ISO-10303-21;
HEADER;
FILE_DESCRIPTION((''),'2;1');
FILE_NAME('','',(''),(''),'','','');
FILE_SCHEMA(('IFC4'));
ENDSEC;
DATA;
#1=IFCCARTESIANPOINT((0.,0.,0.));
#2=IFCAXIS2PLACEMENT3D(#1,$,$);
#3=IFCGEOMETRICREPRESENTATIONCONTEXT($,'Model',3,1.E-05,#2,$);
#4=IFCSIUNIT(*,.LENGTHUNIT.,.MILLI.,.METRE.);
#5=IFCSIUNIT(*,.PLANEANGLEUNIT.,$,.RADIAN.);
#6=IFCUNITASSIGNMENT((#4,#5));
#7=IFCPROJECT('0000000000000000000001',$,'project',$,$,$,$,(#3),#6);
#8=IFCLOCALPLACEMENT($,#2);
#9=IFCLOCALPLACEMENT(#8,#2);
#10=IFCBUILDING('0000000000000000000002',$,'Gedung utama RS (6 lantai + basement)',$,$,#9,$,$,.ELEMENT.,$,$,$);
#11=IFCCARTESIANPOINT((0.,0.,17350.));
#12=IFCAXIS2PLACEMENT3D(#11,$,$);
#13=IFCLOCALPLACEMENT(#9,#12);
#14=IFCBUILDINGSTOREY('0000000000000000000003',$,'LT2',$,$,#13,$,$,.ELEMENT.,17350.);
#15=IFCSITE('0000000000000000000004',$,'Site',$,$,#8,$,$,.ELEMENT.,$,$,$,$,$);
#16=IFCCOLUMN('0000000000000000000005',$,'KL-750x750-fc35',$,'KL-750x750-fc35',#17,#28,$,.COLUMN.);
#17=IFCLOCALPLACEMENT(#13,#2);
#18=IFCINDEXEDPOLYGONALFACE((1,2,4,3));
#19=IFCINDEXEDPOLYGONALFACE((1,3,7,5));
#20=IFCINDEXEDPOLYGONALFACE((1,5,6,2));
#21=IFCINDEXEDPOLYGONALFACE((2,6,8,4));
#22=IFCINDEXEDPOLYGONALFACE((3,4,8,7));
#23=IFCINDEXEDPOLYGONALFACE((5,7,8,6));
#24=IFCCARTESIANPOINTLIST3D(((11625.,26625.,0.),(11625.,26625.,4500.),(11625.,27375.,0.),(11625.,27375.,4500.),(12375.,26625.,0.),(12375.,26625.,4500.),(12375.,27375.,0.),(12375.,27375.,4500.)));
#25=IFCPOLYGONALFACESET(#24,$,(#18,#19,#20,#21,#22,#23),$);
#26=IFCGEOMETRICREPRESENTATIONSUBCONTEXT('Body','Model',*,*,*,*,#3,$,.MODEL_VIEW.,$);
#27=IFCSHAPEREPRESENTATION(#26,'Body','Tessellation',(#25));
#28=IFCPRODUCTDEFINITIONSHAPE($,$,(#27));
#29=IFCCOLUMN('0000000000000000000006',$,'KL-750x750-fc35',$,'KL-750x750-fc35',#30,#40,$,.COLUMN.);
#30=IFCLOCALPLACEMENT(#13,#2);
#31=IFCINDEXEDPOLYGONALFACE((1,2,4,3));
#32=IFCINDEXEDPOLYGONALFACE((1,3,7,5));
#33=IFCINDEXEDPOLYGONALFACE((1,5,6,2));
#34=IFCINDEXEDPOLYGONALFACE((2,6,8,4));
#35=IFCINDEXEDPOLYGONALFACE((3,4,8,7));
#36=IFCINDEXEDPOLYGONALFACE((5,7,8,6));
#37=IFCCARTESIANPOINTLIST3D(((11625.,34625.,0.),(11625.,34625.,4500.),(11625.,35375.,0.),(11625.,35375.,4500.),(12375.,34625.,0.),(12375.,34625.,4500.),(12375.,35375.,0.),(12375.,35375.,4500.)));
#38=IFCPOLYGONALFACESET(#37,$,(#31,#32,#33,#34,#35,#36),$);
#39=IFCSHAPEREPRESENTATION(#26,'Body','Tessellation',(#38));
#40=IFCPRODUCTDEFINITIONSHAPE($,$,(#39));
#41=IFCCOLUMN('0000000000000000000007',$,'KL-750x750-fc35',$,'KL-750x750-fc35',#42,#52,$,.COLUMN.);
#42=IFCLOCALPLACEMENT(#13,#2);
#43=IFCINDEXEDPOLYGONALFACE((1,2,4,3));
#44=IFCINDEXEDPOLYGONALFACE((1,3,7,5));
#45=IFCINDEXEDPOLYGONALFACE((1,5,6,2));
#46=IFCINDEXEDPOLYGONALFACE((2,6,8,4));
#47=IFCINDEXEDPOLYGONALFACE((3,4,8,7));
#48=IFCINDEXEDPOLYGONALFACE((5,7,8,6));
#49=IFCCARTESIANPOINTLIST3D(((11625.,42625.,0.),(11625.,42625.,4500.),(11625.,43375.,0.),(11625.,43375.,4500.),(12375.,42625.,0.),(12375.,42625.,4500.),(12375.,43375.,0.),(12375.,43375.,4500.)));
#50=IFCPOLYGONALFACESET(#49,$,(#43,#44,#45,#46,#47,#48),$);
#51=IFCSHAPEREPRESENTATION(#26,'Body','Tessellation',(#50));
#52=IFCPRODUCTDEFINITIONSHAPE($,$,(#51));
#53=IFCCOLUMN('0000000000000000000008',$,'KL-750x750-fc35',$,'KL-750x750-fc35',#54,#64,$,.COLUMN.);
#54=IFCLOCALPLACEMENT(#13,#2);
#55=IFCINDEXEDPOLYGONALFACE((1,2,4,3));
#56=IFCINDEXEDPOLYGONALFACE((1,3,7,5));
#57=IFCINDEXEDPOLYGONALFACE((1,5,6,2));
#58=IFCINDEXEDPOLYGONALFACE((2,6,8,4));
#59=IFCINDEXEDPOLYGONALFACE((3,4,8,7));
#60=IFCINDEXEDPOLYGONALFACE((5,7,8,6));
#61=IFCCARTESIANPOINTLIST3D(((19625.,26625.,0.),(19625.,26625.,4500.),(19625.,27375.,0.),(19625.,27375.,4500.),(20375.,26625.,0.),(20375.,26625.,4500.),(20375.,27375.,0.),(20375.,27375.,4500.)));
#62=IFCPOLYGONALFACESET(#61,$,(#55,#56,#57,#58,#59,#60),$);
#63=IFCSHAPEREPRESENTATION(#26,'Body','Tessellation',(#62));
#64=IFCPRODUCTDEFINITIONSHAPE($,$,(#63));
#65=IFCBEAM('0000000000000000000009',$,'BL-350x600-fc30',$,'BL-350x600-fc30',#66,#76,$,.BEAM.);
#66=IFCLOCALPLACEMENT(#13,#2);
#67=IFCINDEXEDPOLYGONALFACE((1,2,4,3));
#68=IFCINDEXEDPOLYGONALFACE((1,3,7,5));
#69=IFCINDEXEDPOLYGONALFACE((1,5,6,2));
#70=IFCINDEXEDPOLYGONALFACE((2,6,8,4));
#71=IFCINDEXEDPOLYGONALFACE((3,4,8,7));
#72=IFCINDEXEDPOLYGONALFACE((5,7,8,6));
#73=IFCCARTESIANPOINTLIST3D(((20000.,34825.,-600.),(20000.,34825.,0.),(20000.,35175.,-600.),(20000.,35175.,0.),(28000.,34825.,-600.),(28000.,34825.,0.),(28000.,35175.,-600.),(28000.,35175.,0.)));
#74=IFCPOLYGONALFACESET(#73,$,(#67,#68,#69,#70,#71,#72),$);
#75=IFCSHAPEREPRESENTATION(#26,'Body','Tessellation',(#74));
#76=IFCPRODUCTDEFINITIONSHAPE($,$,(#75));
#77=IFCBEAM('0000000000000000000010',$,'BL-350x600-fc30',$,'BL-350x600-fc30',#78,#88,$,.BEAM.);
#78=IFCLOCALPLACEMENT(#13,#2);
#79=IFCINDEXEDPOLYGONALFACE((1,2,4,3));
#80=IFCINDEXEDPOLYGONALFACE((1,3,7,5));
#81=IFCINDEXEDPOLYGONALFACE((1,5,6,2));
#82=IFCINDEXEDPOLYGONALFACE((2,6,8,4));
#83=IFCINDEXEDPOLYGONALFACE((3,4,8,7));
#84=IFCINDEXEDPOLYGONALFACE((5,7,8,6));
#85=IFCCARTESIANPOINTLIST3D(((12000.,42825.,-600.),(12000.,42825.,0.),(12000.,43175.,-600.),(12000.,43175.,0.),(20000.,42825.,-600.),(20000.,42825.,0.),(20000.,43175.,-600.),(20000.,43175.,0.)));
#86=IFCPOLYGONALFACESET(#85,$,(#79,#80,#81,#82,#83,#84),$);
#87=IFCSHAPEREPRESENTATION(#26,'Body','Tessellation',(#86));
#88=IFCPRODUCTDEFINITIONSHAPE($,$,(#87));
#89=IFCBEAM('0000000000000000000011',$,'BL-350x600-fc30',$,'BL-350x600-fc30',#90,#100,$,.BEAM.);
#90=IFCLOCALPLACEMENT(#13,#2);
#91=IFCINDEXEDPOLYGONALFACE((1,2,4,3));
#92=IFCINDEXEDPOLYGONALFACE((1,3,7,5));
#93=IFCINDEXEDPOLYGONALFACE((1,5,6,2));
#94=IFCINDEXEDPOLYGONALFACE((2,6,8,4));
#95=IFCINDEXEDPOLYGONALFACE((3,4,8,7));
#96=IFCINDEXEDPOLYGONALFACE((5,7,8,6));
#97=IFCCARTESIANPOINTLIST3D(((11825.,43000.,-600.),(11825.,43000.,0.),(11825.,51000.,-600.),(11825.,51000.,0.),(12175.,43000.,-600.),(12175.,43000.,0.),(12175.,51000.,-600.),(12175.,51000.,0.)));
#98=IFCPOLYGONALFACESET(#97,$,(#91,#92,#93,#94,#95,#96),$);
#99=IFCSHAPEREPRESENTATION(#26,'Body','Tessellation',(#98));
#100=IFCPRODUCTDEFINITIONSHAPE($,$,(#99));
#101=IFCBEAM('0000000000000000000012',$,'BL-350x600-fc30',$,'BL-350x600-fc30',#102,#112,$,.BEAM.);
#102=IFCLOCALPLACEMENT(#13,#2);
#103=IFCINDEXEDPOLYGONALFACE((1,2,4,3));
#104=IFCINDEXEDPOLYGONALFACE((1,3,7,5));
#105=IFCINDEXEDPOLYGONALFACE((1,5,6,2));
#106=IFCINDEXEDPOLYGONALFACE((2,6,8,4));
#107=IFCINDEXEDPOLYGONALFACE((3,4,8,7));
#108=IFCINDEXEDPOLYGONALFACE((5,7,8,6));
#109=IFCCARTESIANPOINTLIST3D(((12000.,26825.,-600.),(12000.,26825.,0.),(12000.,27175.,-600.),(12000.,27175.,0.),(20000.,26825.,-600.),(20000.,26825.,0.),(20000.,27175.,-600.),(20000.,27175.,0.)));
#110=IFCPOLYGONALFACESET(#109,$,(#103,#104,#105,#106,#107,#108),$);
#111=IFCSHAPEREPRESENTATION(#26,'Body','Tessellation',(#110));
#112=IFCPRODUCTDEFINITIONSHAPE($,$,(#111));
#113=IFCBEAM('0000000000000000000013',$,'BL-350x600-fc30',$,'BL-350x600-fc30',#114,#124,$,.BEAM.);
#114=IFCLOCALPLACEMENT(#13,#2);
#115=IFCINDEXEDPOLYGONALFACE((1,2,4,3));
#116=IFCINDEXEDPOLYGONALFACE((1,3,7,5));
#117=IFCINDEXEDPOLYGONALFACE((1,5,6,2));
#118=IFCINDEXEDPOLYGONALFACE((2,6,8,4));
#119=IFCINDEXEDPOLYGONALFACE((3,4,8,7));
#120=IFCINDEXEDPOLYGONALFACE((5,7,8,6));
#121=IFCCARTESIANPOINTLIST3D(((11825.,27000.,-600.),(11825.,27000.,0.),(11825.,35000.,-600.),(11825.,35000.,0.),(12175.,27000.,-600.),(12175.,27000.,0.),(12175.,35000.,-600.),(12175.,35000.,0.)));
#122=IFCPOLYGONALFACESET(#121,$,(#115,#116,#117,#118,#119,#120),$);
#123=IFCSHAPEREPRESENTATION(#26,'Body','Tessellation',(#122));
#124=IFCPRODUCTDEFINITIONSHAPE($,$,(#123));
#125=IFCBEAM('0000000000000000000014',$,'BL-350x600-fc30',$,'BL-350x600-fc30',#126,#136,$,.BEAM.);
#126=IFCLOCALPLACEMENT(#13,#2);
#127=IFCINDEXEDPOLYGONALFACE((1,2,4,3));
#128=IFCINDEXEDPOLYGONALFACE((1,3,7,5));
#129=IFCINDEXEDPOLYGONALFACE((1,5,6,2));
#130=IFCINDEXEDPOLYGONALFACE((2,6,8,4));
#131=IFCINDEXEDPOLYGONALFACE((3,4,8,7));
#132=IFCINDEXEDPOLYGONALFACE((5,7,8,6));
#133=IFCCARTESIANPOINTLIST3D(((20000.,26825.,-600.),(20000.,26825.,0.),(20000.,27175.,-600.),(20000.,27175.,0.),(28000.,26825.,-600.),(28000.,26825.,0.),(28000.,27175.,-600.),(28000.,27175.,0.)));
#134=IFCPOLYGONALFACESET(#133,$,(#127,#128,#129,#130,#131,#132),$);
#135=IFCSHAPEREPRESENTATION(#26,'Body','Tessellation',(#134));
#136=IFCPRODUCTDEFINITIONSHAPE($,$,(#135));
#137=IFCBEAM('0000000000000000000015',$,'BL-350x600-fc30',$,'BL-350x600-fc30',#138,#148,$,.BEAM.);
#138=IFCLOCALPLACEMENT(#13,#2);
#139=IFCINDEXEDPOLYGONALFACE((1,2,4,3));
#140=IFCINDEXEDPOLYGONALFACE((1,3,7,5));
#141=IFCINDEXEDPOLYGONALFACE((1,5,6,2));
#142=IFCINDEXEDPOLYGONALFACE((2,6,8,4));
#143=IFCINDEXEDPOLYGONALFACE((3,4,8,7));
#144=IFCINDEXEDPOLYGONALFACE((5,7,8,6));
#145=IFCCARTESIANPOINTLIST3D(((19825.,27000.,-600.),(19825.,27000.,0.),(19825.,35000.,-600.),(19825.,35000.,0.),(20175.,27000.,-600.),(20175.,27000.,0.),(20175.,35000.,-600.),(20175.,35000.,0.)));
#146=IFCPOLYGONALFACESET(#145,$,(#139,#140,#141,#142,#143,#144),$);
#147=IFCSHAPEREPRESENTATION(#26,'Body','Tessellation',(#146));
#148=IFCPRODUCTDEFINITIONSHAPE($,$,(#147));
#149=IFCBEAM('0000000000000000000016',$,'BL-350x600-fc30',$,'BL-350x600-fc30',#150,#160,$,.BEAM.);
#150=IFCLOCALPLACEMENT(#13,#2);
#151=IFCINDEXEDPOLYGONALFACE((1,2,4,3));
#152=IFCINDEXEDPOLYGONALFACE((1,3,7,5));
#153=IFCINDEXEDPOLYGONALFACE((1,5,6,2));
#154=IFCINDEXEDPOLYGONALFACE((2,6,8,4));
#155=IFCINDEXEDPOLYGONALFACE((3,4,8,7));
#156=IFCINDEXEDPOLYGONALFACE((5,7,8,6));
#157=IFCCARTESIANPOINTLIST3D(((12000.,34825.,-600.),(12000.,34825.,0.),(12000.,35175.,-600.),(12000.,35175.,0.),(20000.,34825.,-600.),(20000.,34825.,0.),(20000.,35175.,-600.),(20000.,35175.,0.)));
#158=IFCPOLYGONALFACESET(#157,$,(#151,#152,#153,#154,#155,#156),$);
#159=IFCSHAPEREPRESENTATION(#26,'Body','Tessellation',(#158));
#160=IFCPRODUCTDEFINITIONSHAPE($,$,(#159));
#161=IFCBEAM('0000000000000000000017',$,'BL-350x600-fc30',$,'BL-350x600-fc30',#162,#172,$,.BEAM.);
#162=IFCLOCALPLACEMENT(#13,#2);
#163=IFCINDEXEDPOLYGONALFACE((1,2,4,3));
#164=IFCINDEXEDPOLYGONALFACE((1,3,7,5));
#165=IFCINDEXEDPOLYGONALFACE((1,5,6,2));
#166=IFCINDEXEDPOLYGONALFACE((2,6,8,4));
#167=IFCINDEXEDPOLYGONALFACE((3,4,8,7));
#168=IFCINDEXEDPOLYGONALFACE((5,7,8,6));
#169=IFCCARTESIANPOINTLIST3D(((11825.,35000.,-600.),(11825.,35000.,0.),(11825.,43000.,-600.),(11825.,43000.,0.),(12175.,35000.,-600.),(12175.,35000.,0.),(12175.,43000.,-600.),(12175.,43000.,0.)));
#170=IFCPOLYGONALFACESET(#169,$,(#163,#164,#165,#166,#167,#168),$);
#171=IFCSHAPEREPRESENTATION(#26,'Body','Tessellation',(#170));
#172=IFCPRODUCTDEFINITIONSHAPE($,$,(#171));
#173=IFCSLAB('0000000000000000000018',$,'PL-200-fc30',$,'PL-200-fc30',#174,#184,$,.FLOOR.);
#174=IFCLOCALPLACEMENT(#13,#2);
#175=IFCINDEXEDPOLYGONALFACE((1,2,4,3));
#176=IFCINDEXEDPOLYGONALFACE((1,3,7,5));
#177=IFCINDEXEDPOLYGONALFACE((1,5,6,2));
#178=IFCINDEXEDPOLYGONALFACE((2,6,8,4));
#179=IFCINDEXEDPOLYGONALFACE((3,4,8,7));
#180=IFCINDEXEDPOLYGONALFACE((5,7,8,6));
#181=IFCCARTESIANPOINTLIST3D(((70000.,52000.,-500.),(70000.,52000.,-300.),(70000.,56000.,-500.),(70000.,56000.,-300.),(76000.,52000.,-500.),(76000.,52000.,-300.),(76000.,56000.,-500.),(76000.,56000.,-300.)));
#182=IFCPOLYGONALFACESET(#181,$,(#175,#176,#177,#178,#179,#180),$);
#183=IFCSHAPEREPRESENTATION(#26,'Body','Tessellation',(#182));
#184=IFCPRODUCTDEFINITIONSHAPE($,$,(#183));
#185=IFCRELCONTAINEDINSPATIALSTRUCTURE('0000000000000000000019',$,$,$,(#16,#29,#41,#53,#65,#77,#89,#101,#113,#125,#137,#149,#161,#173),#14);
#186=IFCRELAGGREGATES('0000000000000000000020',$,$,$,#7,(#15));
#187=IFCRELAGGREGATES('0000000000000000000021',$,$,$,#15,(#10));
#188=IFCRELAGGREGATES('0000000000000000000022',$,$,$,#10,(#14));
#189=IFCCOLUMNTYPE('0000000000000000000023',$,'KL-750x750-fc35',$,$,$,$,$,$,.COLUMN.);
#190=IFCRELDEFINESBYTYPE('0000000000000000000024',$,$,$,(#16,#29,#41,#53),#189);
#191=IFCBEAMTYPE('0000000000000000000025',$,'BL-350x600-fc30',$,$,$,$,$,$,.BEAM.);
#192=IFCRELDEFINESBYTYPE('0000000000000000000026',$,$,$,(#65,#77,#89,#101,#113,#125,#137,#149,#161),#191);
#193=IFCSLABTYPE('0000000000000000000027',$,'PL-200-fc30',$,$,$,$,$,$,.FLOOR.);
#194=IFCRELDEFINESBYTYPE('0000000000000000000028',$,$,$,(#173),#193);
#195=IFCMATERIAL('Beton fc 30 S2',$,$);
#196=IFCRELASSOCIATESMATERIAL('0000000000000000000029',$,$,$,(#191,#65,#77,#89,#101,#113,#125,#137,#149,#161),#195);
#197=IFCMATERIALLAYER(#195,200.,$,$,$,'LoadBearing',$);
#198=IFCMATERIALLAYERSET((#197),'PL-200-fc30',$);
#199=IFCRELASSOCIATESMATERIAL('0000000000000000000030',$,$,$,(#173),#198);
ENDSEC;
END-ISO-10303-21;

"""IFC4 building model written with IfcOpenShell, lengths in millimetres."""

from ifc_helpers import new_model, si_unit, frame, origin, origin_2d, place, context, subcontext, project, spatial, polyline, rectangle, outline, extrude, material, layer, layer_set, layer_usage, material_profile, profile_set, profile_usage, type_object, element, save


model = new_model("IFC4")

# Units and contexts
model_context = context("Model", 3, precision=1e-05, world=origin())
body_context = subcontext(model_context, "Body", "Model", "MODEL_VIEW")
ifc_project = project(units=[si_unit("LENGTHUNIT", "METRE", prefix="MILLI"), si_unit("PLANEANGLEUNIT", "RADIAN")], contexts=[model_context])

# Site, building, storey
site_placement = place(None, origin())
site = spatial("IfcSite", under=ifc_project, at=site_placement, Name="Site", CompositionType="ELEMENT")
building_placement = place(site_placement, origin())
building = spatial("IfcBuilding", under=site, at=building_placement, Name="Gedung utama RS (6 lantai + basement)", CompositionType="ELEMENT")
storey_placement = place(building_placement, frame((0.0, 0.0, 17350.0)))
storey = spatial("IfcBuildingStorey", under=building, at=storey_placement, Name="LT2", CompositionType="ELEMENT", Elevation=17350.0)

# Columns
ifc_material_profile_1 = material_profile(None, rectangle(XDim=750.0, YDim=750.0, at=origin_2d()), Name="KL-750x750-fc35")
ifc_profile_set_1 = profile_set([ifc_material_profile_1], Name="KL-750x750-fc35")
ifc_profile_usage_1 = profile_usage(ifc_profile_set_1, cardinal=5)
column_type = type_object("IfcColumnType", Name="KL-750x750-fc35", PredefinedType="COLUMN", material=ifc_profile_set_1)
for number, where, z_axis, x_axis, name in (
    (1, (12000.0, 27000.0, 0.0), (0.0, 0.0, 1.0), (1.0, 0.0, 0.0), "KL-750x750-fc35"),
    (2, (12000.0, 35000.0, 0.0), (0.0, 0.0, 1.0), (1.0, 0.0, 0.0), "KL-750x750-fc35"),
    (3, (12000.0, 43000.0, 0.0), (0.0, 0.0, 1.0), (1.0, 0.0, 0.0), "KL-750x750-fc35"),
    (4, (20000.0, 27000.0, 0.0), (0.0, 0.0, 1.0), (1.0, 0.0, 0.0), "KL-750x750-fc35"),
):
    element("IfcColumn", number, at=place(storey_placement, frame(where, z_axis=z_axis, x_axis=x_axis)), inside=storey, type_object=column_type, material=ifc_profile_usage_1, Name=name, ObjectType="KL-750x750-fc35", PredefinedType="COLUMN", context=body_context, shape_type="SweptSolid", body=[
        extrude(rectangle(XDim=750.0, YDim=750.0, at=origin_2d()), origin(), (0.0, 0.0, 1.0), 4500.0),
    ])

# Beams
ifc_material = material(Name="Beton fc 30 S2")
ifc_material_profile_2 = material_profile(ifc_material, rectangle(XDim=350.0, YDim=600.0, at=origin_2d()), Name="BL-350x600-fc30")
ifc_profile_set_2 = profile_set([ifc_material_profile_2], Name="BL-350x600-fc30")
ifc_profile_usage_2 = profile_usage(ifc_profile_set_2, cardinal=8)
beam_type = type_object("IfcBeamType", Name="BL-350x600-fc30", PredefinedType="BEAM", material=ifc_profile_set_2)
for number, where, name in (
    (5, (20000.0, 35000.0, -300.0), "BL-350x600-fc30"),
    (6, (12000.0, 43000.0, -300.0), "BL-350x600-fc30"),
):
    element("IfcBeam", number, at=place(storey_placement, frame(where)), inside=storey, type_object=beam_type, material=ifc_profile_usage_2, Name=name, ObjectType="BL-350x600-fc30", PredefinedType="BEAM", context=body_context, shape_type="SweptSolid", body=[
        extrude(rectangle(XDim=350.0, YDim=600.0, at=origin_2d()), frame((0.0, 0.0, 0.0), z_axis=(1.0, 0.0, 0.0), x_axis=(0.0, 1.0, 0.0)), (0.0, 0.0, 1.0), 8000.0),
    ])
beam_1_placement = place(storey_placement, frame((12000.0, 43000.0, -300.0)))
element("IfcBeam", 7, at=beam_1_placement, inside=storey, type_object=beam_type, material=ifc_profile_usage_2, Name="BL-350x600-fc30", ObjectType="BL-350x600-fc30", PredefinedType="BEAM", context=body_context, shape_type="SweptSolid", body=[
    extrude(rectangle(XDim=350.0, YDim=600.0, at=origin_2d()), frame((0.0, 0.0, 0.0), z_axis=(0.0, 1.0, 0.0), x_axis=(-1.0, 0.0, 0.0)), (0.0, 0.0, 1.0), 8000.0),
])
beam_2_placement = place(storey_placement, frame((12000.0, 27000.0, -300.0)))
element("IfcBeam", 8, at=beam_2_placement, inside=storey, type_object=beam_type, material=ifc_profile_usage_2, Name="BL-350x600-fc30", ObjectType="BL-350x600-fc30", PredefinedType="BEAM", context=body_context, shape_type="SweptSolid", body=[
    extrude(rectangle(XDim=350.0, YDim=600.0, at=origin_2d()), frame((0.0, 0.0, 0.0), z_axis=(1.0, 0.0, 0.0), x_axis=(0.0, 1.0, 0.0)), (0.0, 0.0, 1.0), 8000.0),
])
beam_3_placement = place(storey_placement, frame((12000.0, 27000.0, -300.0)))
element("IfcBeam", 9, at=beam_3_placement, inside=storey, type_object=beam_type, material=ifc_profile_usage_2, Name="BL-350x600-fc30", ObjectType="BL-350x600-fc30", PredefinedType="BEAM", context=body_context, shape_type="SweptSolid", body=[
    extrude(rectangle(XDim=350.0, YDim=600.0, at=origin_2d()), frame((0.0, 0.0, 0.0), z_axis=(0.0, 1.0, 0.0), x_axis=(-1.0, 0.0, 0.0)), (0.0, 0.0, 1.0), 8000.0),
])
beam_4_placement = place(storey_placement, frame((20000.0, 27000.0, -300.0)))
element("IfcBeam", 10, at=beam_4_placement, inside=storey, type_object=beam_type, material=ifc_profile_usage_2, Name="BL-350x600-fc30", ObjectType="BL-350x600-fc30", PredefinedType="BEAM", context=body_context, shape_type="SweptSolid", body=[
    extrude(rectangle(XDim=350.0, YDim=600.0, at=origin_2d()), frame((0.0, 0.0, 0.0), z_axis=(1.0, 0.0, 0.0), x_axis=(0.0, 1.0, 0.0)), (0.0, 0.0, 1.0), 8000.0),
])
beam_5_placement = place(storey_placement, frame((20000.0, 27000.0, -300.0)))
element("IfcBeam", 11, at=beam_5_placement, inside=storey, type_object=beam_type, material=ifc_profile_usage_2, Name="BL-350x600-fc30", ObjectType="BL-350x600-fc30", PredefinedType="BEAM", context=body_context, shape_type="SweptSolid", body=[
    extrude(rectangle(XDim=350.0, YDim=600.0, at=origin_2d()), frame((0.0, 0.0, 0.0), z_axis=(0.0, 1.0, 0.0), x_axis=(-1.0, 0.0, 0.0)), (0.0, 0.0, 1.0), 8000.0),
])
beam_6_placement = place(storey_placement, frame((12000.0, 35000.0, -300.0)))
element("IfcBeam", 12, at=beam_6_placement, inside=storey, type_object=beam_type, material=ifc_profile_usage_2, Name="BL-350x600-fc30", ObjectType="BL-350x600-fc30", PredefinedType="BEAM", context=body_context, shape_type="SweptSolid", body=[
    extrude(rectangle(XDim=350.0, YDim=600.0, at=origin_2d()), frame((0.0, 0.0, 0.0), z_axis=(1.0, 0.0, 0.0), x_axis=(0.0, 1.0, 0.0)), (0.0, 0.0, 1.0), 8000.0),
])
beam_7_placement = place(storey_placement, frame((12000.0, 35000.0, -300.0)))
element("IfcBeam", 13, at=beam_7_placement, inside=storey, type_object=beam_type, material=ifc_profile_usage_2, Name="BL-350x600-fc30", ObjectType="BL-350x600-fc30", PredefinedType="BEAM", context=body_context, shape_type="SweptSolid", body=[
    extrude(rectangle(XDim=350.0, YDim=600.0, at=origin_2d()), frame((0.0, 0.0, 0.0), z_axis=(0.0, 1.0, 0.0), x_axis=(-1.0, 0.0, 0.0)), (0.0, 0.0, 1.0), 8000.0),
])

# Slab
ifc_layer_1 = layer(ifc_material, 200.0, Category="LoadBearing")
ifc_layer_set_1 = layer_set([ifc_layer_1], Name="PL-200-fc30")
ifc_layer_usage_1 = layer_usage(ifc_layer_set_1, "AXIS3", "NEGATIVE", -300.0)
slab_type_1 = type_object("IfcSlabType", Name="PL-200-fc30", PredefinedType="FLOOR")
slab_1_placement = place(storey_placement, origin())
element("IfcSlab", 14, at=slab_1_placement, inside=storey, type_object=slab_type_1, material=ifc_layer_usage_1, Name="PL-200-fc30", ObjectType="PL-200-fc30", PredefinedType="FLOOR", context=body_context, shape_type="SweptSolid", body=[
    extrude(outline(polyline([(76000.0, 52000.0), (76000.0, 56000.0), (70000.0, 56000.0), (70000.0, 52000.0), (76000.0, 52000.0)])), frame((0.0, 0.0, -500.0)), (0.0, 0.0, 1.0), 200.0),
])

save(model, "model.ifc")
